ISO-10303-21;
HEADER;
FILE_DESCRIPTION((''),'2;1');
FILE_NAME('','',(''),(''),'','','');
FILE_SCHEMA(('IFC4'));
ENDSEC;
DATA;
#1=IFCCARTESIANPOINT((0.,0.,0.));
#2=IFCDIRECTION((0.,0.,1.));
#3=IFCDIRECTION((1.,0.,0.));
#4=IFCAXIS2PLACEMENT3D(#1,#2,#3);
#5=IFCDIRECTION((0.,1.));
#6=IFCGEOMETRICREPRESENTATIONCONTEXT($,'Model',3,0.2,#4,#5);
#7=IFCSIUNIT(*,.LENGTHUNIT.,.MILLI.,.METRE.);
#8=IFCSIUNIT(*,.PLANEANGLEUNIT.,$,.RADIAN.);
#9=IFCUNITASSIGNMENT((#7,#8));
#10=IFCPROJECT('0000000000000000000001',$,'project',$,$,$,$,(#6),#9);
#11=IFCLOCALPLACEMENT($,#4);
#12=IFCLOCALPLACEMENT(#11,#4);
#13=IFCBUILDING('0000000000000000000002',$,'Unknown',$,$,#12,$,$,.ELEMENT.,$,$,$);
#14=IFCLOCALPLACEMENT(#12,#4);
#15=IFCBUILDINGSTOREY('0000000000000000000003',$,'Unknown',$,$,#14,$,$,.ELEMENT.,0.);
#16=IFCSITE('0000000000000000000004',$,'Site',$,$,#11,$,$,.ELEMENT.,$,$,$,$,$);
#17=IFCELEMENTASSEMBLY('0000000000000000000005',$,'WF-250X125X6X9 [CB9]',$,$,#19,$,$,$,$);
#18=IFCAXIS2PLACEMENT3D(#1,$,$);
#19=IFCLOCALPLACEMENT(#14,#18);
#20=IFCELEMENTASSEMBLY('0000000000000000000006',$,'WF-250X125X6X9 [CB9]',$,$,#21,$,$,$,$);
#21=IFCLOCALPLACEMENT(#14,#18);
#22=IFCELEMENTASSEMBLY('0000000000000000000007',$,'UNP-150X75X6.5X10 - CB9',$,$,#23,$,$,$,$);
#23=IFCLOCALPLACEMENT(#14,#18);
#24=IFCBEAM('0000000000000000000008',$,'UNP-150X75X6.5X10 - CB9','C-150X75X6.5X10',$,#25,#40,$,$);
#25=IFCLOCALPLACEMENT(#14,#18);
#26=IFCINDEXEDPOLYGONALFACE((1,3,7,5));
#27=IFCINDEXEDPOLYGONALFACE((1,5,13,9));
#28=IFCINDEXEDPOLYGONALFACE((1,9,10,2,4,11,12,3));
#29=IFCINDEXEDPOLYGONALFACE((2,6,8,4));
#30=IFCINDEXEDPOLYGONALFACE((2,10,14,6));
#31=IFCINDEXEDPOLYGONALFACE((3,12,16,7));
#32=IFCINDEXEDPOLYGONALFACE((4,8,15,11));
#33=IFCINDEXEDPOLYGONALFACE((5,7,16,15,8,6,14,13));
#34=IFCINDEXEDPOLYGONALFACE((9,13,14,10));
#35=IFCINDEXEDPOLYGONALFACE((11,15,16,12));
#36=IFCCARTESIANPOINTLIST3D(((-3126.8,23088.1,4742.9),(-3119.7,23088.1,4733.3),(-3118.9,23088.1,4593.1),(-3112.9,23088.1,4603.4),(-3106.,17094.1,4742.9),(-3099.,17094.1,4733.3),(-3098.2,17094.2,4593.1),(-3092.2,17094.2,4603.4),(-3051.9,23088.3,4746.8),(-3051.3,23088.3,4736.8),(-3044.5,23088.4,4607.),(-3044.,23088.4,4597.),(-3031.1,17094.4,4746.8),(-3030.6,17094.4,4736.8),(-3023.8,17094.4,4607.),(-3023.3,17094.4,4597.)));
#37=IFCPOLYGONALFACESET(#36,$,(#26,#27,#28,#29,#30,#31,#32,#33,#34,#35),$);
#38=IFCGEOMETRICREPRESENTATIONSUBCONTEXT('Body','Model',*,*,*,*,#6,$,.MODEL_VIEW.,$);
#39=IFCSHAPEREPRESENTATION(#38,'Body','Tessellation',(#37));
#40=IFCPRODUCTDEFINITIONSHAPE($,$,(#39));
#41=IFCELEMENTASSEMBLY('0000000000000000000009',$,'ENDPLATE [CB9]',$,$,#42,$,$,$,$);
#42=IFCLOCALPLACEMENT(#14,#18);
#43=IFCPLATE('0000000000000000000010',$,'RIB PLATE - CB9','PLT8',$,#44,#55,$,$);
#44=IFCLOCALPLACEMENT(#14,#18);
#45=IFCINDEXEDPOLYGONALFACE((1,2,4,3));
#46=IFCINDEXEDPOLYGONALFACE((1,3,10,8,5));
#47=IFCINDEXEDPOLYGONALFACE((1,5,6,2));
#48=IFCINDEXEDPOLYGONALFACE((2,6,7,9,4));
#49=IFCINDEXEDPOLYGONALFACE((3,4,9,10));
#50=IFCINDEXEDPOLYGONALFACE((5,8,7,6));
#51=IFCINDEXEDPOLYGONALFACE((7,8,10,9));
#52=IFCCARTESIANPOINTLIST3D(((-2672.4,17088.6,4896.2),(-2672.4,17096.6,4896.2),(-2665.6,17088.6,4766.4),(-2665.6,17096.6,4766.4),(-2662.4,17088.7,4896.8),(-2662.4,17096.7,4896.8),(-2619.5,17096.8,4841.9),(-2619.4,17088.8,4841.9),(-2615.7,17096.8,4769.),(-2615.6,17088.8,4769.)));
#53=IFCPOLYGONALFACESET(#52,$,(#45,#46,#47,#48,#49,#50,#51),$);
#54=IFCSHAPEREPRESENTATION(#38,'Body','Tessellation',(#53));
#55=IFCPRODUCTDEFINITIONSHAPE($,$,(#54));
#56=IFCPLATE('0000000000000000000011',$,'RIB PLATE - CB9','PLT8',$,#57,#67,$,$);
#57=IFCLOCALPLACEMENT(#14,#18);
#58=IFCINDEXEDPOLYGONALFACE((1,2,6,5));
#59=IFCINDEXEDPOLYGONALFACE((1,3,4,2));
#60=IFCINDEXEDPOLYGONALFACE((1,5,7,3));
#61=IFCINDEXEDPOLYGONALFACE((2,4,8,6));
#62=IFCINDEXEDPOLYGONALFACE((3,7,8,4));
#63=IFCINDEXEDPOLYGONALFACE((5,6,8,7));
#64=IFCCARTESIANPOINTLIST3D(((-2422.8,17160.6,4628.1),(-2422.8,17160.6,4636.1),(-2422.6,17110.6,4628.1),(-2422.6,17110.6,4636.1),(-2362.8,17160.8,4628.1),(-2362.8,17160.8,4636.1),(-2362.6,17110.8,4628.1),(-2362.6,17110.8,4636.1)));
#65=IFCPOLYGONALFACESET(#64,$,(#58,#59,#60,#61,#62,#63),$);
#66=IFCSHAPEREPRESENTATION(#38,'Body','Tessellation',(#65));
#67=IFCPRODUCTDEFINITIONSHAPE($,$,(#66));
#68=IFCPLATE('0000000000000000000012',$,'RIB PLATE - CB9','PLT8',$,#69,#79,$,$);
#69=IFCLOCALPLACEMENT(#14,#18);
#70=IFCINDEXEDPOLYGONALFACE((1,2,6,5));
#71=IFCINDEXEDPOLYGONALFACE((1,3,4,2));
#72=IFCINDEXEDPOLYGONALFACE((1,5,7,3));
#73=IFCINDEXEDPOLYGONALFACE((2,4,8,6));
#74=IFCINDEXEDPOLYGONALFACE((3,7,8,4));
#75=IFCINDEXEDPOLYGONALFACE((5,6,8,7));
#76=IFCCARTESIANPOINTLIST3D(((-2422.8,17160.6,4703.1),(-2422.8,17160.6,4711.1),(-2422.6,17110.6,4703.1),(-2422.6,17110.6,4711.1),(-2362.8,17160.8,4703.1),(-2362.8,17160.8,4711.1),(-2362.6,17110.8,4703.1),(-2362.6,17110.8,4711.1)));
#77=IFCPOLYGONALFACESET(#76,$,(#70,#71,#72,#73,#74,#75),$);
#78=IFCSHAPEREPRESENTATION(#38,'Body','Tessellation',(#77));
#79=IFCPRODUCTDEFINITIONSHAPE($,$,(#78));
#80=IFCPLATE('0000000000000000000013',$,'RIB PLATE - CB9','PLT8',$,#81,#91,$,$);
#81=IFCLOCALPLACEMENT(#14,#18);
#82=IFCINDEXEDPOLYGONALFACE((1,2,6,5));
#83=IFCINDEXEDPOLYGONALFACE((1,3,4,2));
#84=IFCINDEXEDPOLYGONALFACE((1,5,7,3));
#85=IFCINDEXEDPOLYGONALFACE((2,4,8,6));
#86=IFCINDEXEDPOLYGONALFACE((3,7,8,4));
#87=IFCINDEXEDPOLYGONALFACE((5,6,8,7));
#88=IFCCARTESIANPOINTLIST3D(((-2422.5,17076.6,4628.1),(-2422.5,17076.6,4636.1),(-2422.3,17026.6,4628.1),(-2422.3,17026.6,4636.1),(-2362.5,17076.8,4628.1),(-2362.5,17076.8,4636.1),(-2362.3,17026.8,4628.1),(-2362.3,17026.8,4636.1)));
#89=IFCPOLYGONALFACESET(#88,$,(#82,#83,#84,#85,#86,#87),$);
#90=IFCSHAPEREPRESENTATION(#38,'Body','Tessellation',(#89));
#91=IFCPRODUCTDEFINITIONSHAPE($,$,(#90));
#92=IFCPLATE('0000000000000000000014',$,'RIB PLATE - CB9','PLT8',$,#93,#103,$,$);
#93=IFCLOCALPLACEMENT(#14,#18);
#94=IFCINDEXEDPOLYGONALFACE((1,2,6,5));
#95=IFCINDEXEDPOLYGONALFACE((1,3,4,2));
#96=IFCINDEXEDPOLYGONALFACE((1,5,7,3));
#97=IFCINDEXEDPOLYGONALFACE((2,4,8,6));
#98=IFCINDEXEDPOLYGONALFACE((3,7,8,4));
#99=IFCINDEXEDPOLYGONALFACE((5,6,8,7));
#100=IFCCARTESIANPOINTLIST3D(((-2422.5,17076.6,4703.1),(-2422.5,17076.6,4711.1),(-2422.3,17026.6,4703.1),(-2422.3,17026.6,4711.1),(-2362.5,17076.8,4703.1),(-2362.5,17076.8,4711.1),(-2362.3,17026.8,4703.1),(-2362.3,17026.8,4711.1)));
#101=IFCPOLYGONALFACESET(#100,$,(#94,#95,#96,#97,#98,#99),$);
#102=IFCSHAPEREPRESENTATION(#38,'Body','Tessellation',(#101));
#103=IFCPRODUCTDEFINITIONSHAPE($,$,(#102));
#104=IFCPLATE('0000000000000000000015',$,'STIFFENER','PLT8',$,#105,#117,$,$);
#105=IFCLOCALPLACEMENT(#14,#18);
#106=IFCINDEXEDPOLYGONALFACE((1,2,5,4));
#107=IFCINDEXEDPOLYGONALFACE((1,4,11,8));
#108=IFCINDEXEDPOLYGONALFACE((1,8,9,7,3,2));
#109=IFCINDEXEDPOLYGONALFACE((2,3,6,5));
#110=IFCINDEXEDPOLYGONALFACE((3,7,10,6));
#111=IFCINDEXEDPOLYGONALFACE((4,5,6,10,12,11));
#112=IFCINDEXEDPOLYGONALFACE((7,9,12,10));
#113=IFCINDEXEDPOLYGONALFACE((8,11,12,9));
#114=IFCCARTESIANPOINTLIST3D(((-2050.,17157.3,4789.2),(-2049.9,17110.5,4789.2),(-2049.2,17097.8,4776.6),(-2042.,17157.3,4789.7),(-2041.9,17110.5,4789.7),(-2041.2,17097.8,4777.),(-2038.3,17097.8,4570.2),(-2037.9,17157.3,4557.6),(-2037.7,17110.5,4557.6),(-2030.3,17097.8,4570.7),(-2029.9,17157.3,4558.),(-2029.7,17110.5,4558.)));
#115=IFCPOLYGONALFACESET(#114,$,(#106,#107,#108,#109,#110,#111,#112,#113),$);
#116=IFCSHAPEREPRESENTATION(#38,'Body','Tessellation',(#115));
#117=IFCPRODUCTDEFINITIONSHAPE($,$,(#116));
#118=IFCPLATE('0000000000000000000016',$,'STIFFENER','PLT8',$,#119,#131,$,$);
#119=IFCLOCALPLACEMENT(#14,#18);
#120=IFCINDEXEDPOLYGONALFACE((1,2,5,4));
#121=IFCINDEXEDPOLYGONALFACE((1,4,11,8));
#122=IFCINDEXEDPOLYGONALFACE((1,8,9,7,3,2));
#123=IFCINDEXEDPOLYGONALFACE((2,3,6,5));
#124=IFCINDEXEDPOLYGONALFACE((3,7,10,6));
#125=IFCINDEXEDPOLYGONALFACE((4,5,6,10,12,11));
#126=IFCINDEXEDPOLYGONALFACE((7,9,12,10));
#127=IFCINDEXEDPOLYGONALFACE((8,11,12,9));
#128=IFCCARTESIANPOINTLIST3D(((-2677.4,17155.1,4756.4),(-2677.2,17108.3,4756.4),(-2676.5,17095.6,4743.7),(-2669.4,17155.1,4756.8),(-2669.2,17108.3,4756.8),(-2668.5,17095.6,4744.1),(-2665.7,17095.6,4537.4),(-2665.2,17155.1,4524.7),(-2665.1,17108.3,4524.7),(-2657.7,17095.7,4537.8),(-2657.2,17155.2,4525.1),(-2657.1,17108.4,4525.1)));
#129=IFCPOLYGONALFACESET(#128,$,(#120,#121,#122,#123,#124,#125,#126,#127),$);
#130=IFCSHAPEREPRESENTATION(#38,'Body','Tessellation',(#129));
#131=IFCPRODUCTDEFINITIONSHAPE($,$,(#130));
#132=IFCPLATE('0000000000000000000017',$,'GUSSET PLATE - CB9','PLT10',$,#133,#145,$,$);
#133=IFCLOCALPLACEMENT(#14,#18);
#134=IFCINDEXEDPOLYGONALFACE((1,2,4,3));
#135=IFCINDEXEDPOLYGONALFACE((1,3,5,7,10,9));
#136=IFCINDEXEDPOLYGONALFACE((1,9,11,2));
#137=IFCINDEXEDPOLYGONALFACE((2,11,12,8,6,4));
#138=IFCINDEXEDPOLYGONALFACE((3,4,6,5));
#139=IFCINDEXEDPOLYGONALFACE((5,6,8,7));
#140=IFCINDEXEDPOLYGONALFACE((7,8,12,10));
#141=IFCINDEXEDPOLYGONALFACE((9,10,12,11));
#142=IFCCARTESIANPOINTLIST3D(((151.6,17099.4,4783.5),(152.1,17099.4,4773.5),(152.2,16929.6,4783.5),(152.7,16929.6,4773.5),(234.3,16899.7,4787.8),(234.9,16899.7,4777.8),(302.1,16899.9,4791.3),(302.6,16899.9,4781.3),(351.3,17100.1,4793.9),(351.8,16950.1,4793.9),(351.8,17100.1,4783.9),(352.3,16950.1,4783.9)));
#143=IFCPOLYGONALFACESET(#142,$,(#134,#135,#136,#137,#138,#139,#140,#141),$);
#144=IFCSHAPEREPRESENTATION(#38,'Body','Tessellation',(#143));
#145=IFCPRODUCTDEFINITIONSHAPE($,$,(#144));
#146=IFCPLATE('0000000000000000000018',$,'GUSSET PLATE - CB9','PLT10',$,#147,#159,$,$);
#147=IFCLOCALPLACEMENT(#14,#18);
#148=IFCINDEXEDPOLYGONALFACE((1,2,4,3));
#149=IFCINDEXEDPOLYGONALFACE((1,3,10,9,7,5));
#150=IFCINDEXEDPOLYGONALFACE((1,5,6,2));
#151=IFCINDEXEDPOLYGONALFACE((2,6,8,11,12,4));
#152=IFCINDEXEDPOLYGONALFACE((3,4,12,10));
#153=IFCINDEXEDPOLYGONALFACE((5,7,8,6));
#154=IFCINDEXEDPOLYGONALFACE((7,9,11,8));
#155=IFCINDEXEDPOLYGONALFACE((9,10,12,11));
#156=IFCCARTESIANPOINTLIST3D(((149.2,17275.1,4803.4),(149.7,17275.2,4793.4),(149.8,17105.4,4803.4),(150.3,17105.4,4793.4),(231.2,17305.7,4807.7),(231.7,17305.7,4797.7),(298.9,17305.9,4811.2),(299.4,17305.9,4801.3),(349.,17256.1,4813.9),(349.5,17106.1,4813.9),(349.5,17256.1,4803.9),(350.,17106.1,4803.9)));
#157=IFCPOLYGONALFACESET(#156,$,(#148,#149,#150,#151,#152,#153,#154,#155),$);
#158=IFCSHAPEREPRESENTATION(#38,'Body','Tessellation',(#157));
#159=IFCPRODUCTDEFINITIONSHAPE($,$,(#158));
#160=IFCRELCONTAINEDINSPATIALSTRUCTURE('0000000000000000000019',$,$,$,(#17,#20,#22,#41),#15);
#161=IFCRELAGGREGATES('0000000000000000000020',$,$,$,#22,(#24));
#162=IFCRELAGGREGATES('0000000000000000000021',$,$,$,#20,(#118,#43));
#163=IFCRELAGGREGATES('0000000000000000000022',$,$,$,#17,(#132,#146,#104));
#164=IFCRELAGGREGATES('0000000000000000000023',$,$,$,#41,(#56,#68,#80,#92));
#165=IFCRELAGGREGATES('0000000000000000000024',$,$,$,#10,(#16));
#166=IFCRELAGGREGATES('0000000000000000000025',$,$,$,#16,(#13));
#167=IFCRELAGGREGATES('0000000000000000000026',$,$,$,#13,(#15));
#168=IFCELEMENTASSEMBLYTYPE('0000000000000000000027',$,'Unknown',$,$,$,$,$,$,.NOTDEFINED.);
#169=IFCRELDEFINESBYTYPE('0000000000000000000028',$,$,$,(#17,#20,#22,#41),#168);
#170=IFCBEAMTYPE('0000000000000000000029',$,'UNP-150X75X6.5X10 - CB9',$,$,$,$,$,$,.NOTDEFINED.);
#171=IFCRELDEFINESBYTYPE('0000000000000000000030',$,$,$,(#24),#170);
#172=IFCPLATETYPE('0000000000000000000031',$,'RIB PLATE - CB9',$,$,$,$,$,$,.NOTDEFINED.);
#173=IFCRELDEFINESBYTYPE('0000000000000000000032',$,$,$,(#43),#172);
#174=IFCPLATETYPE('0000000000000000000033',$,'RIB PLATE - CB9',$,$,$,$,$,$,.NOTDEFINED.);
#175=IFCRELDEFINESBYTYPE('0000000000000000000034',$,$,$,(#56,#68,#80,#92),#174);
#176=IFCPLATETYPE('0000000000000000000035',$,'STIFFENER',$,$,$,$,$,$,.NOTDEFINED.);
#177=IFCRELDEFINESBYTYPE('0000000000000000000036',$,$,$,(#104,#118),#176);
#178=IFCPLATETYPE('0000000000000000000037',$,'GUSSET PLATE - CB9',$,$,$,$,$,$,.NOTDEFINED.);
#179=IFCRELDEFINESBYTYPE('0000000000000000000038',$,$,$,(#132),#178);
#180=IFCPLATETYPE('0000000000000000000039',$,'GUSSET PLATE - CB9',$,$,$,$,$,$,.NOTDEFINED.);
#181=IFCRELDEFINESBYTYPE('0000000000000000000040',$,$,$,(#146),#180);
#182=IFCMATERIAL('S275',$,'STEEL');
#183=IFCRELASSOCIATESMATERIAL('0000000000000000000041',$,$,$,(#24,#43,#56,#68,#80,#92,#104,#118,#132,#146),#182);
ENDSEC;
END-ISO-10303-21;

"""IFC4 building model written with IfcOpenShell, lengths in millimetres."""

from ifc_helpers import new_model, si_unit, direction, frame, origin_with_axes, place, context, subcontext, project, spatial, polyline, line, indexed_curve, outline, extrude, material, material_profile, profile_set, profile_usage, type_object, element, aggregate, save


model = new_model("IFC4")

# Units and contexts
model_context = context("Model", 3, precision=0.2, world=origin_with_axes(), true_north=direction((0.0, 1.0)))
body_context = subcontext(model_context, "Body", "Model", "MODEL_VIEW")
ifc_project = project(units=[si_unit("LENGTHUNIT", "METRE", prefix="MILLI"), si_unit("PLANEANGLEUNIT", "RADIAN")], contexts=[model_context])

# Site, building, storey
site_placement = place(None, origin_with_axes())
site = spatial("IfcSite", under=ifc_project, at=site_placement, Name="Site", CompositionType="ELEMENT")
building_placement = place(site_placement, origin_with_axes())
building = spatial("IfcBuilding", under=site, at=building_placement, Name="Unknown", CompositionType="ELEMENT")
storey_placement = place(building_placement, origin_with_axes())
storey = spatial("IfcBuildingStorey", under=building, at=storey_placement, Name="Unknown", CompositionType="ELEMENT", Elevation=0.0)

# Element assemblies, beam
element_assembly_type = type_object("IfcElementAssemblyType", Name="Unknown", PredefinedType="NOTDEFINED")
ifc_material_1 = material(Name="S275", Category="STEEL")
assembly_1_placement = place(storey_placement, frame((-2248.2, 17094.1, 4662.7), z_axis=(0.003456, -0.999994, 0.0), x_axis=(0.998624, 0.003452, 0.052336)))
assembly_1 = element("IfcElementAssembly", 1, at=assembly_1_placement, inside=storey, type_object=element_assembly_type, Name="WF-250X125X6X9 [CB9]")
assembly_2_placement = place(storey_placement, frame((-3099.5, 17091.1, 4618.1), z_axis=(0.003456, -0.999994, 0.0), x_axis=(0.998624, 0.003452, 0.052336)))
assembly_2 = element("IfcElementAssembly", 2, at=assembly_2_placement, inside=storey, type_object=element_assembly_type, Name="WF-250X125X6X9 [CB9]")
assembly_3_placement = place(storey_placement, frame((-3064.7, 17094.3, 4670.0), z_axis=(0.998624, 0.003452, 0.052336), x_axis=(-0.003457, 0.999994, 0.0)))
assembly_3 = element("IfcElementAssembly", 3, at=assembly_3_placement, inside=storey, type_object=element_assembly_type, Name="UNP-150X75X6.5X10 - CB9")
ifc_material_profile_1 = material_profile(ifc_material_1, outline(polyline([(-37.5, -75.0), (37.5, -75.0), (37.5, -65.0), (-31.0, -65.0), (-31.0, 65.0), (37.5, 65.0), (37.5, 75.0), (-37.5, 75.0), (-37.5, -75.0)])), Name="C-150X75X6.5X10")
ifc_profile_set_1 = profile_set([ifc_material_profile_1])
ifc_profile_usage_1 = profile_usage(ifc_profile_set_1, cardinal=8)
beam_type_1 = type_object("IfcBeamType", Name="UNP-150X75X6.5X10 - CB9", PredefinedType="NOTDEFINED")
beam_1_placement = place(assembly_3_placement, origin_with_axes())
beam_1 = element("IfcBeam", 4, at=beam_1_placement, type_object=beam_type_1, material=ifc_profile_usage_1, Name="UNP-150X75X6.5X10 - CB9", Description="C-150X75X6.5X10", context=body_context, shape_type="SolidModel", body=[
    extrude(outline(polyline([(-37.5, -75.0), (37.5, -75.0), (37.5, -65.0), (-31.0, -65.0), (-31.0, 65.0), (37.5, 65.0), (37.5, 75.0), (-37.5, 75.0), (-37.5, -75.0)])), frame((0.0, 0.0, 0.0), z_axis=(-1.0, 0.0, 0.0), x_axis=(0.0, 0.0, 1.0)), (0.0, 0.0, -1.0), 5994.0),
])
aggregate(assembly_3, [beam_1])
assembly_4_placement = place(storey_placement, frame((-2422.5, 17083.2, 4892.0), z_axis=(0.003456, -0.999994, 0.0), x_axis=(0.0, 0.0, -1.0)))
assembly_4 = element("IfcElementAssembly", 5, at=assembly_4_placement, inside=storey, type_object=element_assembly_type, Name="ENDPLATE [CB9]")

# Plates
ifc_material_profile_2 = material_profile(ifc_material_1, outline(indexed_curve([(0.0, 0.0), (130.0, 0.0), (130.0, 10.0), (73.0, 50.0), (0.0, 50.0)], segments=[line(1, 2, 3, 4, 5, 1)])), Name="PLT8")
ifc_profile_set_2 = profile_set([ifc_material_profile_2])
ifc_profile_usage_2 = profile_usage(ifc_profile_set_2, cardinal=5)
plate_type_1 = type_object("IfcPlateType", Name="RIB PLATE - CB9", PredefinedType="NOTDEFINED")
plate_1_placement = place(assembly_2_placement, frame((441.1, 125.4, 0.0), z_axis=(0.0, 0.0, -1.0), x_axis=(0.0, 1.0, 0.0)))
plate_1 = element("IfcPlate", 6, at=plate_1_placement, type_object=plate_type_1, material=ifc_profile_usage_2, Name="RIB PLATE - CB9", Description="PLT8", context=body_context, shape_type="SolidModel", body=[
    extrude(outline(indexed_curve([(0.0, 0.0), (130.0, 0.0), (130.0, 10.0), (73.0, 50.0), (0.0, 50.0)], segments=[line(1, 2, 3, 4, 5, 1)])), frame((0.0, 0.0, 4.0), z_axis=(0.0, 0.0, 1.0), x_axis=(1.0, 0.0, 0.0)), (0.0, 0.0, -1.0), 8.0),
])
ifc_material_profile_3 = material_profile(ifc_material_1, outline(indexed_curve([(0.0, 0.0), (50.0, 0.0), (50.0, 60.0), (0.0, 60.0)], segments=[line(1, 2, 3, 4, 1)])), Name="PLT8")
ifc_profile_set_3 = profile_set([ifc_material_profile_3])
ifc_profile_usage_3 = profile_usage(ifc_profile_set_3, cardinal=5)
plate_type_2 = type_object("IfcPlateType", Name="RIB PLATE - CB9", PredefinedType="NOTDEFINED")
plate_2_placement = place(assembly_4_placement, frame((259.9, 0.0, -27.4), z_axis=(1.0, 0.0, 0.0), x_axis=(0.0, 0.0, -1.0)))
plate_2 = element("IfcPlate", 7, at=plate_2_placement, type_object=plate_type_2, material=ifc_profile_usage_3, Name="RIB PLATE - CB9", Description="PLT8", context=body_context, shape_type="SolidModel", body=[
    extrude(outline(indexed_curve([(0.0, 0.0), (50.0, 0.0), (50.0, 60.0), (0.0, 60.0)], segments=[line(1, 2, 3, 4, 1)])), frame((0.0, 0.0, 4.0), z_axis=(0.0, 0.0, 1.0), x_axis=(1.0, 0.0, 0.0)), (0.0, 0.0, -1.0), 8.0),
])
plate_3_placement = place(assembly_4_placement, frame((184.9, 0.0, -27.4), z_axis=(1.0, 0.0, 0.0), x_axis=(0.0, 0.0, -1.0)))
plate_3 = element("IfcPlate", 8, at=plate_3_placement, type_object=plate_type_2, material=ifc_profile_usage_3, Name="RIB PLATE - CB9", Description="PLT8", context=body_context, shape_type="SolidModel", body=[
    extrude(outline(indexed_curve([(0.0, 0.0), (50.0, 0.0), (50.0, 60.0), (0.0, 60.0)], segments=[line(1, 2, 3, 4, 1)])), frame((0.0, 0.0, 4.0), z_axis=(0.0, 0.0, 1.0), x_axis=(1.0, 0.0, 0.0)), (0.0, 0.0, -1.0), 8.0),
])
plate_4_placement = place(assembly_4_placement, frame((259.9, 60.0, 6.6), z_axis=(1.0, 0.0, 0.0), x_axis=(0.0, 0.0, 1.0)))
plate_4 = element("IfcPlate", 9, at=plate_4_placement, type_object=plate_type_2, material=ifc_profile_usage_3, Name="RIB PLATE - CB9", Description="PLT8", context=body_context, shape_type="SolidModel", body=[
    extrude(outline(indexed_curve([(0.0, 0.0), (50.0, 0.0), (50.0, 60.0), (0.0, 60.0)], segments=[line(1, 2, 3, 4, 1)])), frame((0.0, 0.0, 4.0), z_axis=(0.0, 0.0, 1.0), x_axis=(1.0, 0.0, 0.0)), (0.0, 0.0, -1.0), 8.0),
])
plate_5_placement = place(assembly_4_placement, frame((184.9, 60.0, 6.6), z_axis=(1.0, 0.0, 0.0), x_axis=(0.0, 0.0, 1.0)))
plate_5 = element("IfcPlate", 10, at=plate_5_placement, type_object=plate_type_2, material=ifc_profile_usage_3, Name="RIB PLATE - CB9", Description="PLT8", context=body_context, shape_type="SolidModel", body=[
    extrude(outline(indexed_curve([(0.0, 0.0), (50.0, 0.0), (50.0, 60.0), (0.0, 60.0)], segments=[line(1, 2, 3, 4, 1)])), frame((0.0, 0.0, 4.0), z_axis=(0.0, 0.0, 1.0), x_axis=(1.0, 0.0, 0.0)), (0.0, 0.0, -1.0), 8.0),
])
ifc_material_profile_4 = material_profile(ifc_material_1, outline(indexed_curve([(0.0, 12.7), (12.7, 0.0), (59.5, 0.0), (59.5, 232.0), (12.7, 232.0), (0.0, 219.3)], segments=[line(1, 2, 3, 4, 5, 6, 1)])), Name="PLT8")
ifc_profile_set_4 = profile_set([ifc_material_profile_4])
ifc_profile_usage_4 = profile_usage(ifc_profile_set_4, cardinal=2)
plate_type_3 = type_object("IfcPlateType", Name="STIFFENER", PredefinedType="NOTDEFINED")
plate_6_placement = place(assembly_1_placement, frame((208.7, 116.0, -3.0), z_axis=(-1.0, 0.0, 0.0), x_axis=(0.0, 0.0, -1.0)))
plate_6 = element("IfcPlate", 11, at=plate_6_placement, type_object=plate_type_3, material=ifc_profile_usage_4, Name="STIFFENER", Description="PLT8", context=body_context, shape_type="SolidModel", body=[
    extrude(outline(indexed_curve([(0.0, 12.7), (12.7, 0.0), (59.5, 0.0), (59.5, 232.0), (12.7, 232.0), (0.0, 219.3)], segments=[line(1, 2, 3, 4, 5, 6, 1)])), frame((0.0, 0.0, 4.0), z_axis=(0.0, 0.0, 1.0), x_axis=(1.0, 0.0, 0.0)), (0.0, 0.0, -1.0), 8.0),
])
plate_7_placement = place(assembly_2_placement, frame((433.0, 116.0, -3.0), z_axis=(-1.0, 0.0, 0.0), x_axis=(0.0, 0.0, -1.0)))
plate_7 = element("IfcPlate", 12, at=plate_7_placement, type_object=plate_type_3, material=ifc_profile_usage_4, Name="STIFFENER", Description="PLT8", context=body_context, shape_type="SolidModel", body=[
    extrude(outline(indexed_curve([(0.0, 12.7), (12.7, 0.0), (59.5, 0.0), (59.5, 232.0), (12.7, 232.0), (0.0, 219.3)], segments=[line(1, 2, 3, 4, 5, 6, 1)])), frame((0.0, 0.0, 4.0), z_axis=(0.0, 0.0, 1.0), x_axis=(1.0, 0.0, 0.0)), (0.0, 0.0, -1.0), 8.0),
])
aggregate(assembly_2, [plate_7, plate_1])
ifc_material_profile_5 = material_profile(ifc_material_1, outline(indexed_curve([(0.0, 0.0), (169.8, 0.0), (200.0, 82.2), (200.0, 150.0), (150.0, 200.0), (0.0, 200.0)], segments=[line(1, 2, 3, 4, 5, 6, 1)])), Name="PLT10")
ifc_profile_set_5 = profile_set([ifc_material_profile_5])
ifc_profile_usage_5 = profile_usage(ifc_profile_set_5, cardinal=5)
plate_type_4 = type_object("IfcPlateType", Name="GUSSET PLATE - CB9", PredefinedType="NOTDEFINED")
plate_8_placement = place(assembly_1_placement, frame((2402.8, -10.0, 3.0), z_axis=(0.0, 1.0, 0.0), x_axis=(0.0, 0.0, 1.0)))
plate_8 = element("IfcPlate", 13, at=plate_8_placement, type_object=plate_type_4, material=ifc_profile_usage_5, Name="GUSSET PLATE - CB9", Description="PLT10", context=body_context, shape_type="SolidModel", body=[
    extrude(outline(indexed_curve([(0.0, 0.0), (169.8, 0.0), (200.0, 82.2), (200.0, 150.0), (150.0, 200.0), (0.0, 200.0)], segments=[line(1, 2, 3, 4, 5, 6, 1)])), frame((0.0, 0.0, 5.0), z_axis=(0.0, 0.0, 1.0), x_axis=(1.0, 0.0, 0.0)), (0.0, 0.0, -1.0), 10.0),
])
ifc_material_profile_6 = material_profile(ifc_material_1, outline(indexed_curve([(0.0, 0.0), (169.8, 0.0), (200.0, 82.2), (200.0, 150.0), (150.0, 200.0), (0.0, 200.0)], segments=[line(1, 2, 3, 4, 5, 6, 1)])), Name="PLT10")
ifc_profile_set_6 = profile_set([ifc_material_profile_6])
ifc_profile_usage_6 = profile_usage(ifc_profile_set_6, cardinal=5)
plate_type_5 = type_object("IfcPlateType", Name="GUSSET PLATE - CB9", PredefinedType="NOTDEFINED")
plate_9_placement = place(assembly_1_placement, frame((2402.1, 10.0, -3.0), z_axis=(0.0, -1.0, 0.0), x_axis=(0.0, 0.0, -1.0)))
plate_9 = element("IfcPlate", 14, at=plate_9_placement, type_object=plate_type_5, material=ifc_profile_usage_6, Name="GUSSET PLATE - CB9", Description="PLT10", context=body_context, shape_type="SolidModel", body=[
    extrude(outline(indexed_curve([(0.0, 0.0), (169.8, 0.0), (200.0, 82.2), (200.0, 150.0), (150.0, 200.0), (0.0, 200.0)], segments=[line(1, 2, 3, 4, 5, 6, 1)])), frame((0.0, 0.0, 5.0), z_axis=(0.0, 0.0, 1.0), x_axis=(1.0, 0.0, 0.0)), (0.0, 0.0, -1.0), 10.0),
])
aggregate(assembly_1, [plate_8, plate_9, plate_6])

aggregate(assembly_4, [plate_2, plate_3, plate_4, plate_5])

save(model, "model.ifc")
